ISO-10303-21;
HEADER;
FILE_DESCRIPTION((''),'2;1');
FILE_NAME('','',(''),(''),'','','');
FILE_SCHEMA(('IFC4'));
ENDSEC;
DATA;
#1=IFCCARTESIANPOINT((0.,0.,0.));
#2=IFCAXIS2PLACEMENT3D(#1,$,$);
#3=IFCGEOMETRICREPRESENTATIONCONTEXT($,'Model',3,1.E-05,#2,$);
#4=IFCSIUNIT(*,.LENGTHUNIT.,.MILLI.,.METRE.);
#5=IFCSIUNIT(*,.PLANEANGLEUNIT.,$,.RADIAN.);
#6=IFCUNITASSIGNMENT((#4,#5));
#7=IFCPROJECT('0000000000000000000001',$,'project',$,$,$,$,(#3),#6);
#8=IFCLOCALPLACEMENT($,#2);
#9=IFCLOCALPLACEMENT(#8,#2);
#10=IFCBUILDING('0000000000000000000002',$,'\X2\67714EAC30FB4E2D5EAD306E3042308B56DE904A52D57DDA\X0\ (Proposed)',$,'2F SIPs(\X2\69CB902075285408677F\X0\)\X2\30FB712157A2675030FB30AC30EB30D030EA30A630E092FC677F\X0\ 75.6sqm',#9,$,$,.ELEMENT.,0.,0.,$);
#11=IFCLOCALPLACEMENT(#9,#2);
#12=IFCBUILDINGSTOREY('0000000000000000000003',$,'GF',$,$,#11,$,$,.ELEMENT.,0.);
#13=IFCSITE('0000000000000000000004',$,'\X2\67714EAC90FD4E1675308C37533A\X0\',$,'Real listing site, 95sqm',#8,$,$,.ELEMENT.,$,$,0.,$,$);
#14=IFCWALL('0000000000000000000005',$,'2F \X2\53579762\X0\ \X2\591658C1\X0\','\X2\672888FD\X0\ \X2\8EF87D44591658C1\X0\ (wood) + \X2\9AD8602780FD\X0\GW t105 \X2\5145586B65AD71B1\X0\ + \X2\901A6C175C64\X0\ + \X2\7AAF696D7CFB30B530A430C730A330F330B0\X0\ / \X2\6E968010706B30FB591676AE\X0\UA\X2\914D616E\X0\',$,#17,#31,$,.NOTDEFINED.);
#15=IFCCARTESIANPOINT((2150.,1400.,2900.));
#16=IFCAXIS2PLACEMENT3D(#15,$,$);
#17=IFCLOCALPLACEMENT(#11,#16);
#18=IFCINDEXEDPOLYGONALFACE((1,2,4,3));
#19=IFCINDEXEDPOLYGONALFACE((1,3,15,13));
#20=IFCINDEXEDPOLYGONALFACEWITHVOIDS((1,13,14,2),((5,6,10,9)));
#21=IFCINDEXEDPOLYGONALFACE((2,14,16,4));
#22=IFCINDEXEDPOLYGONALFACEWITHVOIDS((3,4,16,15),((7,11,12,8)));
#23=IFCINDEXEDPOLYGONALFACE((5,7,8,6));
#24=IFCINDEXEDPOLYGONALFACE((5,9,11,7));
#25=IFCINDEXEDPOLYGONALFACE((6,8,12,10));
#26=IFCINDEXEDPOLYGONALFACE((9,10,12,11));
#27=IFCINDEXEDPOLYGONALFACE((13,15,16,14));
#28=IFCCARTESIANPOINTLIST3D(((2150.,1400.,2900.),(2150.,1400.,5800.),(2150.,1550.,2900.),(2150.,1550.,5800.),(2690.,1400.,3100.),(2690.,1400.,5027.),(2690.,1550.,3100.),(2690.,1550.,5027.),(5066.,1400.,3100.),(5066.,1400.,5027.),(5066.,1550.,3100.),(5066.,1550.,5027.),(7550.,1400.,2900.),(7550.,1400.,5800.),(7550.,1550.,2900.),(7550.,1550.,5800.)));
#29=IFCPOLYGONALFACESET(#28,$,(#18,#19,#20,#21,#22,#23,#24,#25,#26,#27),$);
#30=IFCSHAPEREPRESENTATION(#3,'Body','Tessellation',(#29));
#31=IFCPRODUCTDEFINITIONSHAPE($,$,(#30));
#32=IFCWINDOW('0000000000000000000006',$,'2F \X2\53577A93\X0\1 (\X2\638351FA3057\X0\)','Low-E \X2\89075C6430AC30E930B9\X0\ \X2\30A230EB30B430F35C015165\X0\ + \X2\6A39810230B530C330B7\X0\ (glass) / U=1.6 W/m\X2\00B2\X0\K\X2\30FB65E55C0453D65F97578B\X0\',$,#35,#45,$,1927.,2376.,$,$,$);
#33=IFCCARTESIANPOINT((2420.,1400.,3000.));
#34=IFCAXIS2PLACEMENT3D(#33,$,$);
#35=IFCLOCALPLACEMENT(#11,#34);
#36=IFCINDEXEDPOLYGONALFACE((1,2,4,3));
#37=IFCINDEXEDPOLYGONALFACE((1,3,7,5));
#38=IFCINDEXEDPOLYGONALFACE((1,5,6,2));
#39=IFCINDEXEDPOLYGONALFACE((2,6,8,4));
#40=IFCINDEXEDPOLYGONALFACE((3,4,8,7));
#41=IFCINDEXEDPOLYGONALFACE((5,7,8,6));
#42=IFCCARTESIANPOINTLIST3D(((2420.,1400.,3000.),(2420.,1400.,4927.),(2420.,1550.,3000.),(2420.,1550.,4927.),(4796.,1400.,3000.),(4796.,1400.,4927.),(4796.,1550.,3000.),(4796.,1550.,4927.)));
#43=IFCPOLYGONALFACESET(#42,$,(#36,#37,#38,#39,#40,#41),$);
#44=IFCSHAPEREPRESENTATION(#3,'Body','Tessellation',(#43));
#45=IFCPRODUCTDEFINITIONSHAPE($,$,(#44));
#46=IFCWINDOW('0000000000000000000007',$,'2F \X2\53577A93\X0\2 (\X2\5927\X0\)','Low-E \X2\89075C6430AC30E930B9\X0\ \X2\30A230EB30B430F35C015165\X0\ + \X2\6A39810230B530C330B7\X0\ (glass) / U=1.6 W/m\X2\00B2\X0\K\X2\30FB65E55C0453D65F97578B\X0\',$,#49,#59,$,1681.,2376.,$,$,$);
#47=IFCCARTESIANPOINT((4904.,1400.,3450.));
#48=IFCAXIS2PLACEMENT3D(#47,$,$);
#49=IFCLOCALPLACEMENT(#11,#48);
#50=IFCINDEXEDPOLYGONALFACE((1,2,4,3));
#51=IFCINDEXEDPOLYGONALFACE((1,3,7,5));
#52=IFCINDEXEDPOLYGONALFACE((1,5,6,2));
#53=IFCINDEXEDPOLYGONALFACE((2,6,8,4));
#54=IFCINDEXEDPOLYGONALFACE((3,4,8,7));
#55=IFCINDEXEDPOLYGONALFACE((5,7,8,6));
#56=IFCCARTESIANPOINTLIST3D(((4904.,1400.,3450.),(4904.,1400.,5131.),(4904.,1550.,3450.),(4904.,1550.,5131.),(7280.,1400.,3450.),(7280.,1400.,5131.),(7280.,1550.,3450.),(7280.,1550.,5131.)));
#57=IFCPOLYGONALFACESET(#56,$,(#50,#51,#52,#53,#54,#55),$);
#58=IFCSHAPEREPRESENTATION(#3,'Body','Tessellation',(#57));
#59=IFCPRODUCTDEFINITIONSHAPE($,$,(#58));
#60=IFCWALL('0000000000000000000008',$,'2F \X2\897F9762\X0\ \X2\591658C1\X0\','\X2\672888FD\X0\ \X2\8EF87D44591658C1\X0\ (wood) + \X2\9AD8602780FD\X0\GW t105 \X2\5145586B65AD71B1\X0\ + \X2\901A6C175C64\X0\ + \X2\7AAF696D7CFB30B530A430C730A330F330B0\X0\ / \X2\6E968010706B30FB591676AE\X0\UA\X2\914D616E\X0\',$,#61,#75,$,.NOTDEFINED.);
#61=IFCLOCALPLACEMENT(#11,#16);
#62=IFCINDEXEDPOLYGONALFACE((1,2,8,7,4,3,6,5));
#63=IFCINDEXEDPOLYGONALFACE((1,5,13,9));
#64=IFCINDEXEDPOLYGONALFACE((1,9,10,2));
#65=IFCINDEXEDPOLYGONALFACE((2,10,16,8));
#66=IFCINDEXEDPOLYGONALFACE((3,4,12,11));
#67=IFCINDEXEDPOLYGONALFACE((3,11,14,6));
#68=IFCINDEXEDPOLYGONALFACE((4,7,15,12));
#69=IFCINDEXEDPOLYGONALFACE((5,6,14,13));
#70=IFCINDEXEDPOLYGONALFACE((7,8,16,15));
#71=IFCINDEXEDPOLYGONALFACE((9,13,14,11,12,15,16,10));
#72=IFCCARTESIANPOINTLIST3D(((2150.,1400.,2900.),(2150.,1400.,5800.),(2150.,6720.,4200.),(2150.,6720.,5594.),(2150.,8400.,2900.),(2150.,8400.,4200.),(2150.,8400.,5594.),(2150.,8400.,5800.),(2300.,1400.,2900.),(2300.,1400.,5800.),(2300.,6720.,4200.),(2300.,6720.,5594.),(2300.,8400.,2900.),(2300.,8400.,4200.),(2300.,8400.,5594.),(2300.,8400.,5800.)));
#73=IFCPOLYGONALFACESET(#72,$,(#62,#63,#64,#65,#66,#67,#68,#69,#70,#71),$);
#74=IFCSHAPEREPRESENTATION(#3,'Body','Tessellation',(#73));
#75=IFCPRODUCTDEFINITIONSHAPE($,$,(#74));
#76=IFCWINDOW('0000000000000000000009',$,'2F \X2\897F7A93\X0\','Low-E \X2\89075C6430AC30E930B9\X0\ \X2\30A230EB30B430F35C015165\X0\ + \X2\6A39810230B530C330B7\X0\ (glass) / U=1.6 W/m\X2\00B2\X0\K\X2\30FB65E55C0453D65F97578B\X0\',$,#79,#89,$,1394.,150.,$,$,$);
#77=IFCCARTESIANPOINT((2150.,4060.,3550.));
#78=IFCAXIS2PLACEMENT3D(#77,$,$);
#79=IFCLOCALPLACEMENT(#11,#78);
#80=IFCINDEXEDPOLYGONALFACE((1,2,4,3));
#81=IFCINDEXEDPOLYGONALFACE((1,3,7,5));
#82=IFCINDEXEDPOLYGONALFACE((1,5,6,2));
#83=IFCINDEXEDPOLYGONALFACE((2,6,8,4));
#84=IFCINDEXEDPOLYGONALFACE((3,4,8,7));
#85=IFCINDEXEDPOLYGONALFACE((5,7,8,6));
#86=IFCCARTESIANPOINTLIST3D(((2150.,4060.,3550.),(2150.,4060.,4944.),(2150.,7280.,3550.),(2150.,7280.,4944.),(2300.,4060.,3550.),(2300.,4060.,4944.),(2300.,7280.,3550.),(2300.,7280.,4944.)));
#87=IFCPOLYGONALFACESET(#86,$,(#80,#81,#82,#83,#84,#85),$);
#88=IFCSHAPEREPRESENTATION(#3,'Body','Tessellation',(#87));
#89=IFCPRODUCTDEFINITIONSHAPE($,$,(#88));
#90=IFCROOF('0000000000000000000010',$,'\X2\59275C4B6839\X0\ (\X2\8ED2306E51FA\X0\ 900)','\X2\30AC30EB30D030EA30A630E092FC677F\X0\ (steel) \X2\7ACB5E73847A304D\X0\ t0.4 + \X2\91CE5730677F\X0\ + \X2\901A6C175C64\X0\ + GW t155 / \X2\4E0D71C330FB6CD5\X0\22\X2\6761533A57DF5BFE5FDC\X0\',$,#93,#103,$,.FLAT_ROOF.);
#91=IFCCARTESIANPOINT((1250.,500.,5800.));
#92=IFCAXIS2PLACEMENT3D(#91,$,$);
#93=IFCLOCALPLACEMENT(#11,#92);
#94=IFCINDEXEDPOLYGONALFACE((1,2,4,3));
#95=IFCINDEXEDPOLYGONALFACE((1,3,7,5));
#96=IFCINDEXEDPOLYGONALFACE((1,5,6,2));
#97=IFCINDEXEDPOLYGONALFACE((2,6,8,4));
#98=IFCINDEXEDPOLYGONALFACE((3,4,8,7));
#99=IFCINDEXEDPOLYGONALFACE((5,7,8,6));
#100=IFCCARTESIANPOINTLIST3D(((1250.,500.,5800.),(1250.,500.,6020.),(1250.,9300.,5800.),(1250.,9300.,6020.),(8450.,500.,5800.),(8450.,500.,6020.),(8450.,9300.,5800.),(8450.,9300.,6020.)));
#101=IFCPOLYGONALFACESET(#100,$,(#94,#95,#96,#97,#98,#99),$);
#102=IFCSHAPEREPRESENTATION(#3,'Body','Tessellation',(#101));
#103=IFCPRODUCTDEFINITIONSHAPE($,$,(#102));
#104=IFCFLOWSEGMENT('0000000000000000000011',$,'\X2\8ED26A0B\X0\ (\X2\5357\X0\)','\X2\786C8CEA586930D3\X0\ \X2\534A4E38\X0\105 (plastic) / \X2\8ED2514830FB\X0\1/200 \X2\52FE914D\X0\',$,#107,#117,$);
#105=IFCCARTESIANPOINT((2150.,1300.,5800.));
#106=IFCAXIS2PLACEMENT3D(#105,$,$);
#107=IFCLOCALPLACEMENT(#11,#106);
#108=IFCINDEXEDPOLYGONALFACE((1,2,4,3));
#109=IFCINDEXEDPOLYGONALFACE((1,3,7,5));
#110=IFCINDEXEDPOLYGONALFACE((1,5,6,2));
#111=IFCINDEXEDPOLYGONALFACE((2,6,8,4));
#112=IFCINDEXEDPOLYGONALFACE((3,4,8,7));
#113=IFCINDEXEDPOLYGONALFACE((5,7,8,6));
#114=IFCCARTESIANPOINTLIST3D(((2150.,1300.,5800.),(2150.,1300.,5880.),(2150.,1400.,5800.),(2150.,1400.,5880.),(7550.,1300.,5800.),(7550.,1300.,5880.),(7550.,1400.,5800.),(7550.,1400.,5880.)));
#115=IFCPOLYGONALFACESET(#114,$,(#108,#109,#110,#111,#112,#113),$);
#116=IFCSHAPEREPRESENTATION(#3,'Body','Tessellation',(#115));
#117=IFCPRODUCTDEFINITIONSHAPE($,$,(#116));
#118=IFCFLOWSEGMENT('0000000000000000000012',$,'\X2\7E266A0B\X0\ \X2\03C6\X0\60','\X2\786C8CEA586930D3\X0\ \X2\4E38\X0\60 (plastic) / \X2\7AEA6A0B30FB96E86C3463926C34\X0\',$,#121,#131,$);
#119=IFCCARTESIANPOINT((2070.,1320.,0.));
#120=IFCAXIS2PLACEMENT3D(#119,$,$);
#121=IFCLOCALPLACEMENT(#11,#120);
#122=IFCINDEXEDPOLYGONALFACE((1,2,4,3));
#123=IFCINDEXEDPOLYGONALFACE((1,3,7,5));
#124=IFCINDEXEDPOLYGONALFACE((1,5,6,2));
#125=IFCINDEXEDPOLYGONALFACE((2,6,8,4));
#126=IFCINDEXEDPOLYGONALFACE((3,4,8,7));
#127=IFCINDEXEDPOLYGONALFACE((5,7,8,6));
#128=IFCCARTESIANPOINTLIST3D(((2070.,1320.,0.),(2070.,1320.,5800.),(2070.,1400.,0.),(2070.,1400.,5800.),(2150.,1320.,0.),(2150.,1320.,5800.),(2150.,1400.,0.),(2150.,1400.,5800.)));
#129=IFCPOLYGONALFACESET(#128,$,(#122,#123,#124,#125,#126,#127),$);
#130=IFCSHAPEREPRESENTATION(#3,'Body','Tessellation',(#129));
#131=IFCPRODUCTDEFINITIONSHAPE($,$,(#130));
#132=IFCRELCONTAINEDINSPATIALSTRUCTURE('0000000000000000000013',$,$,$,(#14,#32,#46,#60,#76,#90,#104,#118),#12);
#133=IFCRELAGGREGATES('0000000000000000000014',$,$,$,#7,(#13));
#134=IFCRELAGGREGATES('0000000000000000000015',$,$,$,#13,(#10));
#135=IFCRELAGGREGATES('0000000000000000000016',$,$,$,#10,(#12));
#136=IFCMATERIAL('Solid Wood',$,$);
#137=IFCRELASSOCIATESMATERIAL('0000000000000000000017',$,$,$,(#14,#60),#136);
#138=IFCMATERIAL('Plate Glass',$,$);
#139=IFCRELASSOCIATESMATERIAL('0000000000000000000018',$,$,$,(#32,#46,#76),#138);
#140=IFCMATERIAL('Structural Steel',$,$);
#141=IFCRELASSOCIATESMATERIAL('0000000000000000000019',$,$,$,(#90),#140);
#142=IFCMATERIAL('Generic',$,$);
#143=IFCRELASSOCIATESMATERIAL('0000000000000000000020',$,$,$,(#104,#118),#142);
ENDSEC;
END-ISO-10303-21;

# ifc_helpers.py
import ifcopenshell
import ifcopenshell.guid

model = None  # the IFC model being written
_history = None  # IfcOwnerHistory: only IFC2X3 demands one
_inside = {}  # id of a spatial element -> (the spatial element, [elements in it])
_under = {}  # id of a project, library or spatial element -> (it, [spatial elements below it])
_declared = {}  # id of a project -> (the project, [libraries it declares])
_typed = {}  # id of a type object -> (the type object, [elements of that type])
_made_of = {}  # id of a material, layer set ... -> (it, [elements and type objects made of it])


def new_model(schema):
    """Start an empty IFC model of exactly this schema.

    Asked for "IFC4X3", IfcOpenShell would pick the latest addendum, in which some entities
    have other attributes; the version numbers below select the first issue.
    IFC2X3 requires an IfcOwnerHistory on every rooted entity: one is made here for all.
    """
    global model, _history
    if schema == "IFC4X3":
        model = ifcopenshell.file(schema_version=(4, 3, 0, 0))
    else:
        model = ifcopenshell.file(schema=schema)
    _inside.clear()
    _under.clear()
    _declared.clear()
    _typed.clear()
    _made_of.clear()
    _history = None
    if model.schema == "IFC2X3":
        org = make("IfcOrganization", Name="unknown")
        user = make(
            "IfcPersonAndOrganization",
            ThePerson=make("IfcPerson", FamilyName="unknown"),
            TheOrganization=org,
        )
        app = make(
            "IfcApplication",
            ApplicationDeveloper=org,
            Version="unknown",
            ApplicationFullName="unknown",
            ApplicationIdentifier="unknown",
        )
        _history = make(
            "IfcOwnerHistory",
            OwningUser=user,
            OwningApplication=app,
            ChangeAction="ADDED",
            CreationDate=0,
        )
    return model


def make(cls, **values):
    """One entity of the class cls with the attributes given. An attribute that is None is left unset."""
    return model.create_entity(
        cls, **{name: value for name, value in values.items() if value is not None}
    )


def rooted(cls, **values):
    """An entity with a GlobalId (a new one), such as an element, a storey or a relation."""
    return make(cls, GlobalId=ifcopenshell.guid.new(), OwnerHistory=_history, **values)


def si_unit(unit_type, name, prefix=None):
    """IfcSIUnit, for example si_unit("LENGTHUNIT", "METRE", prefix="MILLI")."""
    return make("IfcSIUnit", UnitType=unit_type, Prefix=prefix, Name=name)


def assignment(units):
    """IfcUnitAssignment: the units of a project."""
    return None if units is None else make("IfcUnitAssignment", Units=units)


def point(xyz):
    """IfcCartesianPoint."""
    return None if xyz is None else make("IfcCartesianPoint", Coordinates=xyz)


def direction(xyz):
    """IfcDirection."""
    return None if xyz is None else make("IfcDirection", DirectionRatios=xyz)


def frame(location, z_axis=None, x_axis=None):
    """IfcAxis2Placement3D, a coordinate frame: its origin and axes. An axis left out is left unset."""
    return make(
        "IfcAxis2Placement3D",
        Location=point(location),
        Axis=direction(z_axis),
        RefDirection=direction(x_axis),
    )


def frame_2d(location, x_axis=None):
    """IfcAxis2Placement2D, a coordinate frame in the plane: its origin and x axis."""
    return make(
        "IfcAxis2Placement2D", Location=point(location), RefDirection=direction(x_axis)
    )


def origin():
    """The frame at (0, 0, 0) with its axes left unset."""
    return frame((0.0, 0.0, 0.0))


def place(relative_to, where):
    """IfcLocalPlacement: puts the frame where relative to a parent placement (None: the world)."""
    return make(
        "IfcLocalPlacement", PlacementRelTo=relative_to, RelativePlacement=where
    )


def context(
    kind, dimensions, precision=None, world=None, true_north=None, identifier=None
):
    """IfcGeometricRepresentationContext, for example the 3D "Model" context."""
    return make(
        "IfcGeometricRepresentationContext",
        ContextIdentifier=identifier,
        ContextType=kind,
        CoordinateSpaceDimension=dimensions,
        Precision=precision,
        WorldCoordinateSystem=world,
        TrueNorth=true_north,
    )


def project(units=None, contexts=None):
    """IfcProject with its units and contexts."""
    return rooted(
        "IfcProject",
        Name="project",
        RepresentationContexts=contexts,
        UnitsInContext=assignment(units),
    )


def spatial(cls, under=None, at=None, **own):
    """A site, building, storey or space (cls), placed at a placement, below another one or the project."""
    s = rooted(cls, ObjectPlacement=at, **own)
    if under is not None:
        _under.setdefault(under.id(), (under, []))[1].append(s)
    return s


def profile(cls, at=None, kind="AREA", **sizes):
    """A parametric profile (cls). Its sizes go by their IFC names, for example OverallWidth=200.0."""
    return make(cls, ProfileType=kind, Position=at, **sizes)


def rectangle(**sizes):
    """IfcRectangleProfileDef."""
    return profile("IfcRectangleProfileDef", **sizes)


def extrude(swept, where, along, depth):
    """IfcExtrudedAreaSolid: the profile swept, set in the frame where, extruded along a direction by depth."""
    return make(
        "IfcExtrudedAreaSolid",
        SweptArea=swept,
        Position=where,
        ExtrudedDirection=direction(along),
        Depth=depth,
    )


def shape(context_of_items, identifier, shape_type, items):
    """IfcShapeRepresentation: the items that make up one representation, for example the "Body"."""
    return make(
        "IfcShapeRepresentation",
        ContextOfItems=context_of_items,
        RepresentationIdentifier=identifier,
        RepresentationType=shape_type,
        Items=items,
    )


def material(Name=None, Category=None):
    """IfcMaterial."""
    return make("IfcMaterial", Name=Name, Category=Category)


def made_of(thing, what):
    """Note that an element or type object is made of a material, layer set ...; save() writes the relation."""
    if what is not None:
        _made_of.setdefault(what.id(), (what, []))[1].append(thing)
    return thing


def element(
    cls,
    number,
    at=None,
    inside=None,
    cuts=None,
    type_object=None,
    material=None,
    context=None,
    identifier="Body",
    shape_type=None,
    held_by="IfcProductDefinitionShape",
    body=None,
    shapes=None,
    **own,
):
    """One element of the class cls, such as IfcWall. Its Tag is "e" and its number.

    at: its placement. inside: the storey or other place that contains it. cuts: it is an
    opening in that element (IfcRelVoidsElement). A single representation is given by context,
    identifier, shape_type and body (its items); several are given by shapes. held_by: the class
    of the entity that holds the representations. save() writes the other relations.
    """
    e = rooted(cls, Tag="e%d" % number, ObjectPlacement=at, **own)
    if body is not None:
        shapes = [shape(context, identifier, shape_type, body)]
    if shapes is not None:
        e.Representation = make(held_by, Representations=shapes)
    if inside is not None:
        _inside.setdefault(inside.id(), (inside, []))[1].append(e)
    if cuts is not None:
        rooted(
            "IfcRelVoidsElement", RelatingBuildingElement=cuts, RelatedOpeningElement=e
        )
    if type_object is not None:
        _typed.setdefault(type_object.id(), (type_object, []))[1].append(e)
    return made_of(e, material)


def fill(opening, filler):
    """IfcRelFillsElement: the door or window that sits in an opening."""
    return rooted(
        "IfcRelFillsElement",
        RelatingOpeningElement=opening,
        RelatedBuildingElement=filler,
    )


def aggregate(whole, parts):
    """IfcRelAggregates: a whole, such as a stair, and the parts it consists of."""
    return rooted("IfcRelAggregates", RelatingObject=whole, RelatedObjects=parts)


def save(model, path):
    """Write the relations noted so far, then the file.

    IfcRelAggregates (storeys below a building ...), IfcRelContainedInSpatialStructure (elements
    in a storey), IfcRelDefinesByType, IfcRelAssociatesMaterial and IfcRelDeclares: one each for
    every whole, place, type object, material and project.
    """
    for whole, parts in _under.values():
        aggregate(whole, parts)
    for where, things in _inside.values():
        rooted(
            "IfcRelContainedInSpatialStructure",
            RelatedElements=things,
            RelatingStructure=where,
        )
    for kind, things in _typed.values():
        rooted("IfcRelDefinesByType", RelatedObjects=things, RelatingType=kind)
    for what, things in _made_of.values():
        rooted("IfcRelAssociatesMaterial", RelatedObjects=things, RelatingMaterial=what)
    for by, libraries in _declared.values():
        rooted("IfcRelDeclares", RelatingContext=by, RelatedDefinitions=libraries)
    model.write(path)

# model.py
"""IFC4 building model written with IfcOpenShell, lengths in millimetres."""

from ifc_helpers import new_model, si_unit, frame, frame_2d, origin, place, context, project, spatial, rectangle, extrude, material, element, fill, save


model = new_model("IFC4")

# Units and contexts
model_context = context("Model", 3, precision=1e-05, world=origin())
ifc_project = project(units=[si_unit("LENGTHUNIT", "METRE", prefix="MILLI"), si_unit("PLANEANGLEUNIT", "RADIAN")], contexts=[model_context])

# Site, building, storey
site_placement = place(None, origin())
site = spatial("IfcSite", under=ifc_project, at=site_placement, Name="東京都世田谷区", ObjectType="Real listing site, 95sqm", CompositionType="ELEMENT", RefElevation=0.0)
building_placement = place(site_placement, origin())
building = spatial("IfcBuilding", under=site, at=building_placement, Name="東京・中庭のある回遊動線 (Proposed)", ObjectType="2F SIPs(構造用合板)・無垢材・ガルバリウム鋼板 75.6sqm", CompositionType="ELEMENT", ElevationOfRefHeight=0.0, ElevationOfTerrain=0.0)
storey_placement = place(building_placement, origin())
storey = spatial("IfcBuildingStorey", under=building, at=storey_placement, Name="GF", CompositionType="ELEMENT", Elevation=0.0)

# Shared definitions
ifc_material_1 = material(Name="Solid Wood")

# Shared definitions
ifc_material_2 = material(Name="Plate Glass")

# Wall, openings, windows
wall_1_placement = place(storey_placement, frame((2150.0, 1400.0, 2900.0)))
wall_1 = element("IfcWall", 1, at=wall_1_placement, inside=storey, material=ifc_material_1, Name="2F 南面 外壁", Description="木製 軸組外壁 (wood) + 高性能GW t105 充填断熱 + 通気層 + 窯業系サイディング / 準耐火・外皮UA配慮", PredefinedType="NOTDEFINED", context=model_context, shape_type="SweptSolid", body=[
    extrude(rectangle(XDim=5400.0, YDim=150.0, at=frame_2d((2700.0, 75.0))), frame((2150.0, 1400.0, 2900.0)), (0.0, 0.0, 1.0), 2900.0),
])
opening_1_placement = place(storey_placement, frame((2420.0, 1400.0, 3000.0)))
opening_1 = element("IfcOpeningElement", 2, at=opening_1_placement, cuts=wall_1, PredefinedType="NOTDEFINED", context=model_context, shape_type="SweptSolid", body=[
    extrude(rectangle(XDim=2376.0, YDim=150.0, at=frame_2d((1188.0, 75.0))), frame((2420.0, 1400.0, 3000.0)), (0.0, 0.0, 1.0), 1927.0),
])
opening_2_placement = place(storey_placement, frame((4904.0, 1400.0, 3450.0)))
opening_2 = element("IfcOpeningElement", 3, at=opening_2_placement, cuts=wall_1, PredefinedType="NOTDEFINED", context=model_context, shape_type="SweptSolid", body=[
    extrude(rectangle(XDim=2376.0, YDim=150.0, at=frame_2d((1188.0, 75.0))), frame((4904.0, 1400.0, 3450.0)), (0.0, 0.0, 1.0), 1681.0),
])
window_1_placement = place(storey_placement, frame((2420.0, 1400.0, 3000.0)))
window_1 = element("IfcWindow", 4, at=window_1_placement, inside=storey, material=ifc_material_2, Name="2F 南窓1 (掃出し)", Description="Low-E 複層ガラス アルゴン封入 + 樹脂サッシ (glass) / U=1.6 W/m²K・日射取得型", OverallHeight=1927.0, OverallWidth=2376.0, context=model_context, shape_type="SweptSolid", body=[
    extrude(rectangle(XDim=2376.0, YDim=150.0, at=frame_2d((1188.0, 75.0))), frame((2420.0, 1400.0, 3000.0)), (0.0, 0.0, 1.0), 1927.0),
])
fill(opening_1, window_1)
window_2_placement = place(storey_placement, frame((4904.0, 1400.0, 3450.0)))
window_2 = element("IfcWindow", 5, at=window_2_placement, inside=storey, material=ifc_material_2, Name="2F 南窓2 (大)", Description="Low-E 複層ガラス アルゴン封入 + 樹脂サッシ (glass) / U=1.6 W/m²K・日射取得型", OverallHeight=1681.0, OverallWidth=2376.0, context=model_context, shape_type="SweptSolid", body=[
    extrude(rectangle(XDim=2376.0, YDim=150.0, at=frame_2d((1188.0, 75.0))), frame((4904.0, 1400.0, 3450.0)), (0.0, 0.0, 1.0), 1681.0),
])
fill(opening_2, window_2)

# Wall, opening, window
wall_2_placement = place(storey_placement, frame((2150.0, 1400.0, 2900.0)))
wall_2 = element("IfcWall", 6, at=wall_2_placement, inside=storey, material=ifc_material_1, Name="2F 西面 外壁", Description="木製 軸組外壁 (wood) + 高性能GW t105 充填断熱 + 通気層 + 窯業系サイディング / 準耐火・外皮UA配慮", PredefinedType="NOTDEFINED", context=model_context, shape_type="SweptSolid", body=[
    extrude(rectangle(XDim=150.0, YDim=7000.0, at=frame_2d((75.0, 3500.0))), frame((2150.0, 1400.0, 2900.0)), (0.0, 0.0, 1.0), 2900.0),
])
opening_3_placement = place(storey_placement, frame((2150.0, 4060.0, 3550.0)))
opening_3 = element("IfcOpeningElement", 7, at=opening_3_placement, cuts=wall_2, PredefinedType="NOTDEFINED", context=model_context, shape_type="SweptSolid", body=[
    extrude(rectangle(XDim=150.0, YDim=3220.0, at=frame_2d((75.0, 1610.0))), frame((2150.0, 4060.0, 3550.0)), (0.0, 0.0, 1.0), 1394.0),
])
window_3_placement = place(storey_placement, frame((2150.0, 4060.0, 3550.0)))
window_3 = element("IfcWindow", 8, at=window_3_placement, inside=storey, material=ifc_material_2, Name="2F 西窓", Description="Low-E 複層ガラス アルゴン封入 + 樹脂サッシ (glass) / U=1.6 W/m²K・日射取得型", OverallHeight=1394.0, OverallWidth=150.0, context=model_context, shape_type="SweptSolid", body=[
    extrude(rectangle(XDim=150.0, YDim=3220.0, at=frame_2d((75.0, 1610.0))), frame((2150.0, 4060.0, 3550.0)), (0.0, 0.0, 1.0), 1394.0),
])
fill(opening_3, window_3)

# Roof
ifc_material_3 = material(Name="Structural Steel")
roof_placement = place(storey_placement, frame((1250.0, 500.0, 5800.0)))
element("IfcRoof", 9, at=roof_placement, inside=storey, material=ifc_material_3, Name="大屋根 (軒の出 900)", Description="ガルバリウム鋼板 (steel) 立平葺き t0.4 + 野地板 + 通気層 + GW t155 / 不燃・法22条区域対応", PredefinedType="FLAT_ROOF", context=model_context, shape_type="SweptSolid", body=[
    extrude(rectangle(XDim=7200.0, YDim=8800.0, at=frame_2d((3600.0, 4400.0))), frame((1250.0, 500.0, 5800.0)), (0.0, 0.0, 1.0), 220.0),
])

# Flow segments
ifc_material_4 = material(Name="Generic")
flow_segment_1_placement = place(storey_placement, frame((2150.0, 1300.0, 5800.0)))
element("IfcFlowSegment", 10, at=flow_segment_1_placement, inside=storey, material=ifc_material_4, Name="軒樋 (南)", Description="硬質塩ビ 半丸105 (plastic) / 軒先・1/200 勾配", context=model_context, shape_type="SweptSolid", body=[
    extrude(rectangle(XDim=5400.0, YDim=100.0, at=frame_2d((2700.0, 50.0))), frame((2150.0, 1300.0, 5800.0)), (0.0, 0.0, 1.0), 80.0),
])
flow_segment_2_placement = place(storey_placement, frame((2070.0, 1320.0, 0.0)))
element("IfcFlowSegment", 11, at=flow_segment_2_placement, inside=storey, material=ifc_material_4, Name="縦樋 φ60", Description="硬質塩ビ 丸60 (plastic) / 竪樋・雨水排水", context=model_context, shape_type="SweptSolid", body=[
    extrude(rectangle(XDim=80.0, YDim=80.0, at=frame_2d((40.0, 40.0))), frame((2070.0, 1320.0, 0.0)), (0.0, 0.0, 1.0), 5800.0),
])

save(model, "model.ifc")
